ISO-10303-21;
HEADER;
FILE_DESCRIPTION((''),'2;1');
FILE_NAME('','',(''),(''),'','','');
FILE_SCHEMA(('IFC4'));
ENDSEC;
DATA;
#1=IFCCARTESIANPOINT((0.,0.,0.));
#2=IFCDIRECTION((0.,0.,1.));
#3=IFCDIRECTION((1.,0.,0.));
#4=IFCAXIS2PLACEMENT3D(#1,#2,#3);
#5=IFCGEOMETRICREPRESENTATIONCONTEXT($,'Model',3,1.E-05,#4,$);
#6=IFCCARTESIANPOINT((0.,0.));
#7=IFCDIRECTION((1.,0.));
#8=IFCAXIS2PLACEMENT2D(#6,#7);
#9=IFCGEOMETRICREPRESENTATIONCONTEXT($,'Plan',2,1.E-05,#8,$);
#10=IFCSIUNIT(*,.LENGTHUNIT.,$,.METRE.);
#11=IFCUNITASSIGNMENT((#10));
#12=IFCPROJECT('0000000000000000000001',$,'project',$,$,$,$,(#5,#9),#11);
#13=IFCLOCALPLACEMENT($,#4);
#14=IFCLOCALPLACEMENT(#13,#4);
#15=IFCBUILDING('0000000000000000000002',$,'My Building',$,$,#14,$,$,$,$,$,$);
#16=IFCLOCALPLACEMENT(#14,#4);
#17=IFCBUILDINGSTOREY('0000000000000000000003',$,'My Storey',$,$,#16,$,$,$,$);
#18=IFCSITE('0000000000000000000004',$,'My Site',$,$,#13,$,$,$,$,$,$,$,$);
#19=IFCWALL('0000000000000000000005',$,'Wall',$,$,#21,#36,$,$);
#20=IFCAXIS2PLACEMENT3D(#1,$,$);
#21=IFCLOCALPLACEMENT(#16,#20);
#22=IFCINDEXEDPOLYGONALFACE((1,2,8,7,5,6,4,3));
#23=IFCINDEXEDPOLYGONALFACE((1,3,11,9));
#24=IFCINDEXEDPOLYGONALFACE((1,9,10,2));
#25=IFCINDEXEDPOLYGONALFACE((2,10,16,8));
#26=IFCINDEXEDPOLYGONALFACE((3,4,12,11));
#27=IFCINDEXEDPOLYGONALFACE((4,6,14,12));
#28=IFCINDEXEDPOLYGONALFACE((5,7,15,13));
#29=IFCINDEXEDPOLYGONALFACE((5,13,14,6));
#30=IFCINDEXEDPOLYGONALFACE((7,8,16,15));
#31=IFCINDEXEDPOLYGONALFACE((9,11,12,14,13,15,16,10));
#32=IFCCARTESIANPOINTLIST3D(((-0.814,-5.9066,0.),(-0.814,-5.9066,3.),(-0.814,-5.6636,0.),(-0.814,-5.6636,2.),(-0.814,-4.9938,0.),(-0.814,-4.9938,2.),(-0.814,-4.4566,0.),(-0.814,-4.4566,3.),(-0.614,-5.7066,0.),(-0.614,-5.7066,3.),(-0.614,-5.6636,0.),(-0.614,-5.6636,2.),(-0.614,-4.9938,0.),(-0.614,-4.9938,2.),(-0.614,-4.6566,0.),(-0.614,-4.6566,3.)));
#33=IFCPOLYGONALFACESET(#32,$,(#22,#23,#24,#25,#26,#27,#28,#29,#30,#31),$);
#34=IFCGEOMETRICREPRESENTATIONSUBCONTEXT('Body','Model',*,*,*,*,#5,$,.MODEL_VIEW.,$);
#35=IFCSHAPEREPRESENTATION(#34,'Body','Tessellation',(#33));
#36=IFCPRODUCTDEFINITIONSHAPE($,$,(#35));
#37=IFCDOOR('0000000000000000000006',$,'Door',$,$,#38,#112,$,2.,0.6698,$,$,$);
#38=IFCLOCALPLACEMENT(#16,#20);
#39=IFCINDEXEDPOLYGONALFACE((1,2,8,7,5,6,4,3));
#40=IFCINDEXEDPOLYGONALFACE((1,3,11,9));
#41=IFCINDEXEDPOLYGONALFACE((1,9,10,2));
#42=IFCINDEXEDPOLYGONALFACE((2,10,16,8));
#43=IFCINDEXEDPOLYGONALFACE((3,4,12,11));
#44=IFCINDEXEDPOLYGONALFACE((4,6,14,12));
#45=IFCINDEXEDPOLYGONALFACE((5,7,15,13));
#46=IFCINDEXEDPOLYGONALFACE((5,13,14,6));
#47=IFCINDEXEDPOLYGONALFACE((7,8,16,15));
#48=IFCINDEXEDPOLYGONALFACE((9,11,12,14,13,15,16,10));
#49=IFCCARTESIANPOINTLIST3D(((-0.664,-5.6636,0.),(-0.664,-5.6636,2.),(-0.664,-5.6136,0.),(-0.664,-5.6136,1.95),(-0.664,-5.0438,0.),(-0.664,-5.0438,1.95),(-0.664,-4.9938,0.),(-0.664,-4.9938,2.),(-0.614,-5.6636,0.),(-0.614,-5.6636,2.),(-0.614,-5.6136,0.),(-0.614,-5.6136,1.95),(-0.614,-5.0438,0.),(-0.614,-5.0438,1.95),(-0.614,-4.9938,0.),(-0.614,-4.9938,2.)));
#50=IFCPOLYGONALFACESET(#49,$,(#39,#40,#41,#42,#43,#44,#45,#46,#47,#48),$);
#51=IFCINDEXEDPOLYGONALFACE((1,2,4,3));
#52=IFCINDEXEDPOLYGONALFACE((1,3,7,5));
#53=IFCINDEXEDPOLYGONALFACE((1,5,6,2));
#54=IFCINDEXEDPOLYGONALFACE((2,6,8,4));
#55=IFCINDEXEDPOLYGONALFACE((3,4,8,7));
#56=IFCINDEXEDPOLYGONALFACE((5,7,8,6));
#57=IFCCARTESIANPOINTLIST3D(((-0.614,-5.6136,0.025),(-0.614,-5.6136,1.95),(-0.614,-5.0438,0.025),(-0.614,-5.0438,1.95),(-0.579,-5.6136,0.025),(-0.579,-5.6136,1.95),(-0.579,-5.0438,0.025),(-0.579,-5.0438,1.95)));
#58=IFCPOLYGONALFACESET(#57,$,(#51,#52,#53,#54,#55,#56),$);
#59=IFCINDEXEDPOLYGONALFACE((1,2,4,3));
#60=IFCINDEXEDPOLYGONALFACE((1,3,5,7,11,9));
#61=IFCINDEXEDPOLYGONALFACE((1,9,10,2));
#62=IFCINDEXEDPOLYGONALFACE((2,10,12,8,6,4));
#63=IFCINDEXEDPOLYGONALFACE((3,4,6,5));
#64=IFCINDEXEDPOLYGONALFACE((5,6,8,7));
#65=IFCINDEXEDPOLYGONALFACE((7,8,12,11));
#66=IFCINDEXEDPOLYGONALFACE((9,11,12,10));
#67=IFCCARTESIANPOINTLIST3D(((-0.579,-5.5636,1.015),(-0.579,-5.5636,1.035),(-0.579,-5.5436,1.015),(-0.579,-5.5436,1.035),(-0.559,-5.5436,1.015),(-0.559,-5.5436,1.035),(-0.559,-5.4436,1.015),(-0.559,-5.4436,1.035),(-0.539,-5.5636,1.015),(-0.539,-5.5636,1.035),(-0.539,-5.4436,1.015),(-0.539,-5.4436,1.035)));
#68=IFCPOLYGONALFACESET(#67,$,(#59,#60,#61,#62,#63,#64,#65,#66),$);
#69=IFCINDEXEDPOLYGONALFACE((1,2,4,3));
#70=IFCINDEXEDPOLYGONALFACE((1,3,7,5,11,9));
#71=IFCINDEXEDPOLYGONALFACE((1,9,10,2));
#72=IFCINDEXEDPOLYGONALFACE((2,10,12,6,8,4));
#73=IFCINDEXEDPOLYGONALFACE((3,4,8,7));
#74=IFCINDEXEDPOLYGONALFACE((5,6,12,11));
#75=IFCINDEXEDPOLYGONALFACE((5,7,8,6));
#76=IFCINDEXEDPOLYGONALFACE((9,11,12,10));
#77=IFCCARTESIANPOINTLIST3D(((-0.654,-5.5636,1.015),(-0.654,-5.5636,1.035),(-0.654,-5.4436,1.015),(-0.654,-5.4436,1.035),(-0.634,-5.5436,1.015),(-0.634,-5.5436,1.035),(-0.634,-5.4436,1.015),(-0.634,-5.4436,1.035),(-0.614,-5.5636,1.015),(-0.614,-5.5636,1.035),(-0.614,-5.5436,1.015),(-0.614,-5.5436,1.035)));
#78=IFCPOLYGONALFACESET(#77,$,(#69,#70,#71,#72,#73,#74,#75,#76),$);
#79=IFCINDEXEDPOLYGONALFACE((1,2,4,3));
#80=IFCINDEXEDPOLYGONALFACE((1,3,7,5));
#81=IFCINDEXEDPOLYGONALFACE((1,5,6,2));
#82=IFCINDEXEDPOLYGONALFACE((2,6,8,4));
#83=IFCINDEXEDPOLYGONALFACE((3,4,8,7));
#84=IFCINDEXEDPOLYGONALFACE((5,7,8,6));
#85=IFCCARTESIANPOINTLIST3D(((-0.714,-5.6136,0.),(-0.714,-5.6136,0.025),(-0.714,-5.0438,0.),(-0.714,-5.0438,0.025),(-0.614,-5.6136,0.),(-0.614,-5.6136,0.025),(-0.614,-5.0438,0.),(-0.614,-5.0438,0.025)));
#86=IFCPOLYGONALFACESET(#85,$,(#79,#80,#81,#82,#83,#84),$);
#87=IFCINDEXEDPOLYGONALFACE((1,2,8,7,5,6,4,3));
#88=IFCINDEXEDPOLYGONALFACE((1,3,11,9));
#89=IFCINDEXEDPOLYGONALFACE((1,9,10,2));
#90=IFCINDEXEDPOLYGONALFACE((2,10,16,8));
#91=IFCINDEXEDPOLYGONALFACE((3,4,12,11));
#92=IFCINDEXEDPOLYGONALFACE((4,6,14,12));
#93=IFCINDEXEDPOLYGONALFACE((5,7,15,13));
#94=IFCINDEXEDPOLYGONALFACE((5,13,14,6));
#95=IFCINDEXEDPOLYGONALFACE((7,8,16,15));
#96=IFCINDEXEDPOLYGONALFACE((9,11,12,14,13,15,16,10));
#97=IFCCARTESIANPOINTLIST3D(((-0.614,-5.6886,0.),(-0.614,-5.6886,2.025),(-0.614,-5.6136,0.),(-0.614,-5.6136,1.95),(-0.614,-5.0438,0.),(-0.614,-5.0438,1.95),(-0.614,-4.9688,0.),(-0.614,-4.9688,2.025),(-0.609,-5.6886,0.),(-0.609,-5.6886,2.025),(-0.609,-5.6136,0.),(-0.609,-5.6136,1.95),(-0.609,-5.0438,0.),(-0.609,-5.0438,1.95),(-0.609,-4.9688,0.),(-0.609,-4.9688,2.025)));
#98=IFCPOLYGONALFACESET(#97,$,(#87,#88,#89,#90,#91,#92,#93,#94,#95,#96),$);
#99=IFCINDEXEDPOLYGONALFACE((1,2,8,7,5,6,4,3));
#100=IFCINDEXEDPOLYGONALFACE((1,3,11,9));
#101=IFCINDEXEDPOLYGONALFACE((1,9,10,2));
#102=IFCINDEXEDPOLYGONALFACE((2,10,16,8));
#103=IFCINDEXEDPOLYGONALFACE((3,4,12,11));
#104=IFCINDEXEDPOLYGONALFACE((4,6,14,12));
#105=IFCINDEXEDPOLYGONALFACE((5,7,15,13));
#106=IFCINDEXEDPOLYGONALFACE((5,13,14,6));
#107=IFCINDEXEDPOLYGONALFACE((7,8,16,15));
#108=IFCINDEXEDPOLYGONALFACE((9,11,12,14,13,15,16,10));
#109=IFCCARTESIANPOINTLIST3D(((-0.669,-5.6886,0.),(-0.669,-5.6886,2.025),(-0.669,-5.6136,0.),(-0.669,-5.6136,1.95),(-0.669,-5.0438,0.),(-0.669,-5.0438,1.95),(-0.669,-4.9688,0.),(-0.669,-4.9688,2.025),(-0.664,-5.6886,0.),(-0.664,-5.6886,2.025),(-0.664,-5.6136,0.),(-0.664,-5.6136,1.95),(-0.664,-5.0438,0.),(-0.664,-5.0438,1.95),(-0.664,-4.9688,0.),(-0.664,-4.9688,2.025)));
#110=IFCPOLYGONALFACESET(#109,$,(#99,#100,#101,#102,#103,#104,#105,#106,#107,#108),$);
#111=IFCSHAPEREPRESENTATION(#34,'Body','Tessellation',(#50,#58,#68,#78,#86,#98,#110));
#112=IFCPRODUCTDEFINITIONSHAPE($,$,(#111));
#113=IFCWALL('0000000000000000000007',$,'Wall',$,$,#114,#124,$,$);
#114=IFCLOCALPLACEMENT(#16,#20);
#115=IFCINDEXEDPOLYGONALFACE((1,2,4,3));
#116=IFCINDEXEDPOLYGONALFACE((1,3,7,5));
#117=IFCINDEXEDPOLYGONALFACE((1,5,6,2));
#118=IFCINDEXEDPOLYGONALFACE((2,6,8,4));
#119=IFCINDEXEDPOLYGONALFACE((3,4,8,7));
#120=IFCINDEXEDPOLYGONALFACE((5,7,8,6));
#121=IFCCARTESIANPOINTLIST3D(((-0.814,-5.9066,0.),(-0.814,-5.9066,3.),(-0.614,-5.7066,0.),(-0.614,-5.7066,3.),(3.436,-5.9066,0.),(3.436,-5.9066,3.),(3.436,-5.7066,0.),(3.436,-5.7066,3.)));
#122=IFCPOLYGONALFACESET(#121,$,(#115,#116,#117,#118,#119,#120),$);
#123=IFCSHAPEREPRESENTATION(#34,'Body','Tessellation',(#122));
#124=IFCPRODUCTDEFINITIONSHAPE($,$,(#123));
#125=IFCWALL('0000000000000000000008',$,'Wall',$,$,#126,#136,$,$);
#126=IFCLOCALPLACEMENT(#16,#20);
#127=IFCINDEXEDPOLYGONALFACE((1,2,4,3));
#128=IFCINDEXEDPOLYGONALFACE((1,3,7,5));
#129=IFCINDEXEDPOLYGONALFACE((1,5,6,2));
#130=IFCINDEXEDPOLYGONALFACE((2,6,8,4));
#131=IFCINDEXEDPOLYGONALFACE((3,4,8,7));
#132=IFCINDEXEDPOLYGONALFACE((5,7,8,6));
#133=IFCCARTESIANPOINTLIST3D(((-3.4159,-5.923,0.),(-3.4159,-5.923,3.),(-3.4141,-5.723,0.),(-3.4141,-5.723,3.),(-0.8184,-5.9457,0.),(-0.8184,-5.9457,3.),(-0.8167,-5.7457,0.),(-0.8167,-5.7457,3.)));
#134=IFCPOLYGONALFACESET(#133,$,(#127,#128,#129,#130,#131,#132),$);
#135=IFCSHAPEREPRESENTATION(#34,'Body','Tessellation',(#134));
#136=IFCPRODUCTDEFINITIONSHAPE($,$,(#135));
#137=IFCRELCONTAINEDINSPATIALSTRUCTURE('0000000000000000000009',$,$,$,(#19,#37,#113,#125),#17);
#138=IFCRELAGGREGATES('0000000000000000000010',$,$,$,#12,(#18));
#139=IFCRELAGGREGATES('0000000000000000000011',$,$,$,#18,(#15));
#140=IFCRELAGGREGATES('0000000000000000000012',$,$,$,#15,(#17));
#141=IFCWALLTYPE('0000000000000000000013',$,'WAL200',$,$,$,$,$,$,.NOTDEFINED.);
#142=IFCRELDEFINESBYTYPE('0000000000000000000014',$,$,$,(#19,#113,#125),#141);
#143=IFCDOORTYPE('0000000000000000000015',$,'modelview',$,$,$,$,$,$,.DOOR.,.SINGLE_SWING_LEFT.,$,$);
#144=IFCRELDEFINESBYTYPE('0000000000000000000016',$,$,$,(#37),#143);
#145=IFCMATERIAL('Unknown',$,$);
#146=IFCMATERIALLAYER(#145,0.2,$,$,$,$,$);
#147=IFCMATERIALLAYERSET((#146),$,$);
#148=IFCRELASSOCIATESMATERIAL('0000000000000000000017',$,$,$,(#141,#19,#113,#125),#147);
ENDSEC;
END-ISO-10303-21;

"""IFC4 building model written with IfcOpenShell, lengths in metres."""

from ifc_helpers import new_model, entity, si_unit, frame, origin_with_axes, origin_2d_with_axis, place, context, subcontext, project, spatial, line, indexed_curve, outline, extrude, shape, source, transform, mapped, material, layer, layer_set, layer_usage, type_object, type_shapes, element, fill, save


model = new_model("IFC4")

# Units and contexts
model_context = context("Model", 3, precision=1e-05, world=origin_with_axes())
plan_context = context("Plan", 2, precision=1e-05, world=origin_2d_with_axis())
body_context_1 = subcontext(model_context, "Body", "Model", "MODEL_VIEW")
body_context_2 = subcontext(plan_context, "Body", "Plan", "PLAN_VIEW")
ifc_project = project(units=[si_unit("LENGTHUNIT", "METRE")], contexts=[model_context, plan_context])

# Site, building, storey
site_placement = place(None, origin_with_axes())
site = spatial("IfcSite", under=ifc_project, at=site_placement, Name="My Site")
building_placement = place(site_placement, origin_with_axes())
building = spatial("IfcBuilding", under=site, at=building_placement, Name="My Building")
storey_placement = place(building_placement, origin_with_axes())
storey = spatial("IfcBuildingStorey", under=building, at=storey_placement, Name="My Storey")

# Shared definitions
ifc_material = material(Name="Unknown")

# Shared definitions
shared_shape_1 = source(origin_with_axes(), body_context_1, "Body", "SweptSolid", [
    extrude(outline(indexed_curve([(0.0, 0.0), (0.6698, 0.0), (0.6698, 2.0), (0.0, 2.0)], segments=[line(1, 2, 3, 4, 1)])), frame((0.0, -0.6, 0.0), z_axis=(0.0, -1.0, 0.0), x_axis=(1.0, 0.0, 0.0)), (0.0, 0.0, -1.0), 1.2),
])
door_type_1 = type_object("IfcDoorType", Name="modelview", OperationType="SINGLE_SWING_LEFT", PredefinedType="DOOR")
shared_shape_2 = source(origin_with_axes(), body_context_1, "Body", "SweptSolid", [
    extrude(outline(indexed_curve([(0.0, 0.0), (0.0, 2.0), (0.6698, 2.0), (0.6698, 0.0), (0.6198, 0.0), (0.6198, 1.95), (0.05, 1.95), (0.05, 0.0)], segments=[line(1, 2, 3, 4, 5, 6, 7, 8, 1)])), frame((0.0, 0.0, 0.0), z_axis=(0.0, -1.0, 0.0), x_axis=(1.0, 0.0, 0.0)), (0.0, 0.0, -1.0), 0.05),
    extrude(outline(indexed_curve([(0.0, 0.0), (0.5698, 0.0), (0.5698, 0.035), (0.0, 0.035)], segments=[line(1, 2, 3, 4, 1)])), frame((0.05, -0.035, 0.025), z_axis=(0.0, 0.0, 1.0), x_axis=(1.0, 0.0, 0.0)), (0.0, 0.0, 1.0), 1.925),
    extrude(outline(indexed_curve([(0.0, 0.0), (0.0, -0.04), (0.12, -0.04), (0.12, -0.02), (0.02, -0.02), (0.02, 0.0)], segments=[line(1, 2, 3, 4, 5, 6, 1)])), frame((0.1, -0.035, 1.015), z_axis=(0.0, 0.0, 1.0), x_axis=(1.0, 0.0, 0.0)), (0.0, 0.0, 1.0), 0.02),
    extrude(outline(indexed_curve([(0.0, 0.0), (0.0, 0.04), (0.12, 0.04), (0.12, 0.02), (0.02, 0.02), (0.02, 0.0)], segments=[line(1, 2, 3, 4, 5, 6, 1)])), frame((0.1, 0.0, 1.015), z_axis=(0.0, 0.0, 1.0), x_axis=(1.0, 0.0, 0.0)), (0.0, 0.0, 1.0), 0.02),
    extrude(outline(indexed_curve([(0.0, 0.0), (0.5698, 0.0), (0.5698, 0.1), (0.0, 0.1)], segments=[line(1, 2, 3, 4, 1)])), frame((0.05, 0.0, 0.0), z_axis=(0.0, 0.0, 1.0), x_axis=(1.0, 0.0, 0.0)), (0.0, 0.0, 1.0), 0.025),
    extrude(outline(indexed_curve([(0.0, 0.0), (0.0, 2.025), (0.7198, 2.025), (0.7198, 0.0), (0.6448, 0.0), (0.6448, 1.95), (0.075, 1.95), (0.075, 0.0)], segments=[line(1, 2, 3, 4, 5, 6, 7, 8, 1)])), frame((-0.025, -0.005, 0.0), z_axis=(0.0, -1.0, 0.0), x_axis=(1.0, 0.0, 0.0)), (0.0, 0.0, -1.0), 0.005),
    extrude(outline(indexed_curve([(0.0, 0.0), (0.0, 2.025), (0.7198, 2.025), (0.7198, 0.0), (0.6448, 0.0), (0.6448, 1.95), (0.075, 1.95), (0.075, 0.0)], segments=[line(1, 2, 3, 4, 5, 6, 7, 8, 1)])), frame((-0.025, 0.05, 0.0), z_axis=(0.0, -1.0, 0.0), x_axis=(1.0, 0.0, 0.0)), (0.0, 0.0, -1.0), 0.005),
])
shared_shape_3 = source(origin_with_axes(), body_context_2, "Body", "Curve2D", [
    entity("IfcIndexedPolyCurve", entity("IfcCartesianPointList2D", [[0.0, 0.0], [0.05, 0.0], [0.05, 0.05], [0.0, 0.05]]), [entity("IfcLineIndex", [1, 2, 3, 4, 1])]),
    entity("IfcIndexedPolyCurve", entity("IfcCartesianPointList2D", [[0.6698, 0.0], [0.6198, 0.0], [0.6198, 0.05], [0.6698, 0.05]]), [entity("IfcLineIndex", [1, 2, 3, 4, 1])]),
    entity("IfcIndexedPolyCurve", entity("IfcCartesianPointList2D", [[0.9047, -0.035], [0.3349, -0.035], [0.3349, 0.0], [0.9047, 0.0]]), [entity("IfcLineIndex", [1, 2, 3, 4, 1])]),
])
type_shapes(door_type_1, [shared_shape_2, shared_shape_3])

# Shared definitions
ifc_layer_1 = layer(ifc_material, 0.2)
ifc_layer_set_1 = layer_set([ifc_layer_1])
wall_type_1 = type_object("IfcWallType", Name="WAL200", PredefinedType="NOTDEFINED", material=ifc_layer_set_1)

# Wall, opening, door
ifc_layer_usage_1 = layer_usage(ifc_layer_set_1, "AXIS2", "POSITIVE", 0.0)
wall_1_placement = place(storey_placement, frame((-0.814, -4.4566, 0.0), z_axis=(0.0, 0.0, 1.0), x_axis=(0.0, -1.0, 0.0)))
wall_1 = element("IfcWall", 1, at=wall_1_placement, inside=storey, type_object=wall_type_1, material=ifc_layer_usage_1, Name="Wall", context=body_context_1, shape_type="SweptSolid", body=[
    extrude(outline(indexed_curve([(0.0, 0.0), (0.2, 0.2), (1.25, 0.2), (1.45, 0.0)], segments=[line(1, 2, 3, 4, 1)])), origin_with_axes(), (0.0, 0.0, 1.0), 3.0),
])
opening_1_placement = place(wall_1_placement, frame((1.2071, 0.2, 0.0), z_axis=(0.0, 0.0, 1.0), x_axis=(-1.0, 0.0, 0.0)))
opening_1 = element("IfcOpeningElement", 2, at=opening_1_placement, cuts=wall_1, PredefinedType="OPENING", context=body_context_1, shape_type="MappedRepresentation", body=[
    mapped(shared_shape_1, transform((0.0, 0.0, 0.0), x_axis=(1.0, 0.0, 0.0), y_axis=(0.0, 1.0, 0.0), z_axis=(0.0, 0.0, 1.0), scale=1.0)),
])
door_1_placement = place(opening_1_placement, frame((0.0, 0.0, 0.0), z_axis=(0.0, 0.0, 1.0), x_axis=(1.0, 0.0, 0.0)))
door_1 = element("IfcDoor", 3, at=door_1_placement, inside=storey, type_object=door_type_1, Name="Door", OverallHeight=2.0, OverallWidth=0.6698, shapes=[
    shape(body_context_1, "Body", "MappedRepresentation", [mapped(shared_shape_2, transform((0.0, 0.0, 0.0), x_axis=(1.0, 0.0, 0.0), y_axis=(0.0, 1.0, 0.0), z_axis=(0.0, 0.0, 1.0), scale=1.0))]),
    shape(body_context_2, "Body", "MappedRepresentation", [mapped(shared_shape_3, transform((0.0, 0.0, 0.0), x_axis=(1.0, 0.0, 0.0), y_axis=(0.0, 1.0, 0.0), z_axis=(0.0, 0.0, 1.0), scale=1.0))]),
])
fill(opening_1, door_1)

# Walls
ifc_layer_usage_2 = layer_usage(ifc_layer_set_1, "AXIS2", "POSITIVE", 0.0)
wall_2_placement = place(storey_placement, frame((-0.814, -5.9066, 0.0), z_axis=(0.0, 0.0, 1.0), x_axis=(1.0, 0.0, 0.0)))
element("IfcWall", 4, at=wall_2_placement, inside=storey, type_object=wall_type_1, material=ifc_layer_usage_2, Name="Wall", context=body_context_1, shape_type="SweptSolid", body=[
    extrude(outline(indexed_curve([(0.0, 0.0), (0.2, 0.2), (4.25, 0.2), (4.25, 0.0)], segments=[line(1, 2, 3, 4, 1)])), origin_with_axes(), (0.0, 0.0, 1.0), 3.0),
])
ifc_layer_usage_3 = layer_usage(ifc_layer_set_1, "AXIS2", "POSITIVE", 0.0)
wall_3_placement = place(storey_placement, frame((-3.4159, -5.923, 0.0), z_axis=(0.0, 0.0, 1.0), x_axis=(0.999962, -0.008764, 0.0)))
element("IfcWall", 5, at=wall_3_placement, inside=storey, type_object=wall_type_1, material=ifc_layer_usage_3, Name="Wall", context=body_context_1, shape_type="SweptSolid", body=[
    extrude(outline(indexed_curve([(0.0, 0.0), (0.0, 0.2), (2.5975, 0.2), (2.5975, 0.0)], segments=[line(1, 2, 3, 4, 1)])), origin_with_axes(), (0.0, 0.0, 1.0), 3.0),
])

save(model, "model.ifc")
